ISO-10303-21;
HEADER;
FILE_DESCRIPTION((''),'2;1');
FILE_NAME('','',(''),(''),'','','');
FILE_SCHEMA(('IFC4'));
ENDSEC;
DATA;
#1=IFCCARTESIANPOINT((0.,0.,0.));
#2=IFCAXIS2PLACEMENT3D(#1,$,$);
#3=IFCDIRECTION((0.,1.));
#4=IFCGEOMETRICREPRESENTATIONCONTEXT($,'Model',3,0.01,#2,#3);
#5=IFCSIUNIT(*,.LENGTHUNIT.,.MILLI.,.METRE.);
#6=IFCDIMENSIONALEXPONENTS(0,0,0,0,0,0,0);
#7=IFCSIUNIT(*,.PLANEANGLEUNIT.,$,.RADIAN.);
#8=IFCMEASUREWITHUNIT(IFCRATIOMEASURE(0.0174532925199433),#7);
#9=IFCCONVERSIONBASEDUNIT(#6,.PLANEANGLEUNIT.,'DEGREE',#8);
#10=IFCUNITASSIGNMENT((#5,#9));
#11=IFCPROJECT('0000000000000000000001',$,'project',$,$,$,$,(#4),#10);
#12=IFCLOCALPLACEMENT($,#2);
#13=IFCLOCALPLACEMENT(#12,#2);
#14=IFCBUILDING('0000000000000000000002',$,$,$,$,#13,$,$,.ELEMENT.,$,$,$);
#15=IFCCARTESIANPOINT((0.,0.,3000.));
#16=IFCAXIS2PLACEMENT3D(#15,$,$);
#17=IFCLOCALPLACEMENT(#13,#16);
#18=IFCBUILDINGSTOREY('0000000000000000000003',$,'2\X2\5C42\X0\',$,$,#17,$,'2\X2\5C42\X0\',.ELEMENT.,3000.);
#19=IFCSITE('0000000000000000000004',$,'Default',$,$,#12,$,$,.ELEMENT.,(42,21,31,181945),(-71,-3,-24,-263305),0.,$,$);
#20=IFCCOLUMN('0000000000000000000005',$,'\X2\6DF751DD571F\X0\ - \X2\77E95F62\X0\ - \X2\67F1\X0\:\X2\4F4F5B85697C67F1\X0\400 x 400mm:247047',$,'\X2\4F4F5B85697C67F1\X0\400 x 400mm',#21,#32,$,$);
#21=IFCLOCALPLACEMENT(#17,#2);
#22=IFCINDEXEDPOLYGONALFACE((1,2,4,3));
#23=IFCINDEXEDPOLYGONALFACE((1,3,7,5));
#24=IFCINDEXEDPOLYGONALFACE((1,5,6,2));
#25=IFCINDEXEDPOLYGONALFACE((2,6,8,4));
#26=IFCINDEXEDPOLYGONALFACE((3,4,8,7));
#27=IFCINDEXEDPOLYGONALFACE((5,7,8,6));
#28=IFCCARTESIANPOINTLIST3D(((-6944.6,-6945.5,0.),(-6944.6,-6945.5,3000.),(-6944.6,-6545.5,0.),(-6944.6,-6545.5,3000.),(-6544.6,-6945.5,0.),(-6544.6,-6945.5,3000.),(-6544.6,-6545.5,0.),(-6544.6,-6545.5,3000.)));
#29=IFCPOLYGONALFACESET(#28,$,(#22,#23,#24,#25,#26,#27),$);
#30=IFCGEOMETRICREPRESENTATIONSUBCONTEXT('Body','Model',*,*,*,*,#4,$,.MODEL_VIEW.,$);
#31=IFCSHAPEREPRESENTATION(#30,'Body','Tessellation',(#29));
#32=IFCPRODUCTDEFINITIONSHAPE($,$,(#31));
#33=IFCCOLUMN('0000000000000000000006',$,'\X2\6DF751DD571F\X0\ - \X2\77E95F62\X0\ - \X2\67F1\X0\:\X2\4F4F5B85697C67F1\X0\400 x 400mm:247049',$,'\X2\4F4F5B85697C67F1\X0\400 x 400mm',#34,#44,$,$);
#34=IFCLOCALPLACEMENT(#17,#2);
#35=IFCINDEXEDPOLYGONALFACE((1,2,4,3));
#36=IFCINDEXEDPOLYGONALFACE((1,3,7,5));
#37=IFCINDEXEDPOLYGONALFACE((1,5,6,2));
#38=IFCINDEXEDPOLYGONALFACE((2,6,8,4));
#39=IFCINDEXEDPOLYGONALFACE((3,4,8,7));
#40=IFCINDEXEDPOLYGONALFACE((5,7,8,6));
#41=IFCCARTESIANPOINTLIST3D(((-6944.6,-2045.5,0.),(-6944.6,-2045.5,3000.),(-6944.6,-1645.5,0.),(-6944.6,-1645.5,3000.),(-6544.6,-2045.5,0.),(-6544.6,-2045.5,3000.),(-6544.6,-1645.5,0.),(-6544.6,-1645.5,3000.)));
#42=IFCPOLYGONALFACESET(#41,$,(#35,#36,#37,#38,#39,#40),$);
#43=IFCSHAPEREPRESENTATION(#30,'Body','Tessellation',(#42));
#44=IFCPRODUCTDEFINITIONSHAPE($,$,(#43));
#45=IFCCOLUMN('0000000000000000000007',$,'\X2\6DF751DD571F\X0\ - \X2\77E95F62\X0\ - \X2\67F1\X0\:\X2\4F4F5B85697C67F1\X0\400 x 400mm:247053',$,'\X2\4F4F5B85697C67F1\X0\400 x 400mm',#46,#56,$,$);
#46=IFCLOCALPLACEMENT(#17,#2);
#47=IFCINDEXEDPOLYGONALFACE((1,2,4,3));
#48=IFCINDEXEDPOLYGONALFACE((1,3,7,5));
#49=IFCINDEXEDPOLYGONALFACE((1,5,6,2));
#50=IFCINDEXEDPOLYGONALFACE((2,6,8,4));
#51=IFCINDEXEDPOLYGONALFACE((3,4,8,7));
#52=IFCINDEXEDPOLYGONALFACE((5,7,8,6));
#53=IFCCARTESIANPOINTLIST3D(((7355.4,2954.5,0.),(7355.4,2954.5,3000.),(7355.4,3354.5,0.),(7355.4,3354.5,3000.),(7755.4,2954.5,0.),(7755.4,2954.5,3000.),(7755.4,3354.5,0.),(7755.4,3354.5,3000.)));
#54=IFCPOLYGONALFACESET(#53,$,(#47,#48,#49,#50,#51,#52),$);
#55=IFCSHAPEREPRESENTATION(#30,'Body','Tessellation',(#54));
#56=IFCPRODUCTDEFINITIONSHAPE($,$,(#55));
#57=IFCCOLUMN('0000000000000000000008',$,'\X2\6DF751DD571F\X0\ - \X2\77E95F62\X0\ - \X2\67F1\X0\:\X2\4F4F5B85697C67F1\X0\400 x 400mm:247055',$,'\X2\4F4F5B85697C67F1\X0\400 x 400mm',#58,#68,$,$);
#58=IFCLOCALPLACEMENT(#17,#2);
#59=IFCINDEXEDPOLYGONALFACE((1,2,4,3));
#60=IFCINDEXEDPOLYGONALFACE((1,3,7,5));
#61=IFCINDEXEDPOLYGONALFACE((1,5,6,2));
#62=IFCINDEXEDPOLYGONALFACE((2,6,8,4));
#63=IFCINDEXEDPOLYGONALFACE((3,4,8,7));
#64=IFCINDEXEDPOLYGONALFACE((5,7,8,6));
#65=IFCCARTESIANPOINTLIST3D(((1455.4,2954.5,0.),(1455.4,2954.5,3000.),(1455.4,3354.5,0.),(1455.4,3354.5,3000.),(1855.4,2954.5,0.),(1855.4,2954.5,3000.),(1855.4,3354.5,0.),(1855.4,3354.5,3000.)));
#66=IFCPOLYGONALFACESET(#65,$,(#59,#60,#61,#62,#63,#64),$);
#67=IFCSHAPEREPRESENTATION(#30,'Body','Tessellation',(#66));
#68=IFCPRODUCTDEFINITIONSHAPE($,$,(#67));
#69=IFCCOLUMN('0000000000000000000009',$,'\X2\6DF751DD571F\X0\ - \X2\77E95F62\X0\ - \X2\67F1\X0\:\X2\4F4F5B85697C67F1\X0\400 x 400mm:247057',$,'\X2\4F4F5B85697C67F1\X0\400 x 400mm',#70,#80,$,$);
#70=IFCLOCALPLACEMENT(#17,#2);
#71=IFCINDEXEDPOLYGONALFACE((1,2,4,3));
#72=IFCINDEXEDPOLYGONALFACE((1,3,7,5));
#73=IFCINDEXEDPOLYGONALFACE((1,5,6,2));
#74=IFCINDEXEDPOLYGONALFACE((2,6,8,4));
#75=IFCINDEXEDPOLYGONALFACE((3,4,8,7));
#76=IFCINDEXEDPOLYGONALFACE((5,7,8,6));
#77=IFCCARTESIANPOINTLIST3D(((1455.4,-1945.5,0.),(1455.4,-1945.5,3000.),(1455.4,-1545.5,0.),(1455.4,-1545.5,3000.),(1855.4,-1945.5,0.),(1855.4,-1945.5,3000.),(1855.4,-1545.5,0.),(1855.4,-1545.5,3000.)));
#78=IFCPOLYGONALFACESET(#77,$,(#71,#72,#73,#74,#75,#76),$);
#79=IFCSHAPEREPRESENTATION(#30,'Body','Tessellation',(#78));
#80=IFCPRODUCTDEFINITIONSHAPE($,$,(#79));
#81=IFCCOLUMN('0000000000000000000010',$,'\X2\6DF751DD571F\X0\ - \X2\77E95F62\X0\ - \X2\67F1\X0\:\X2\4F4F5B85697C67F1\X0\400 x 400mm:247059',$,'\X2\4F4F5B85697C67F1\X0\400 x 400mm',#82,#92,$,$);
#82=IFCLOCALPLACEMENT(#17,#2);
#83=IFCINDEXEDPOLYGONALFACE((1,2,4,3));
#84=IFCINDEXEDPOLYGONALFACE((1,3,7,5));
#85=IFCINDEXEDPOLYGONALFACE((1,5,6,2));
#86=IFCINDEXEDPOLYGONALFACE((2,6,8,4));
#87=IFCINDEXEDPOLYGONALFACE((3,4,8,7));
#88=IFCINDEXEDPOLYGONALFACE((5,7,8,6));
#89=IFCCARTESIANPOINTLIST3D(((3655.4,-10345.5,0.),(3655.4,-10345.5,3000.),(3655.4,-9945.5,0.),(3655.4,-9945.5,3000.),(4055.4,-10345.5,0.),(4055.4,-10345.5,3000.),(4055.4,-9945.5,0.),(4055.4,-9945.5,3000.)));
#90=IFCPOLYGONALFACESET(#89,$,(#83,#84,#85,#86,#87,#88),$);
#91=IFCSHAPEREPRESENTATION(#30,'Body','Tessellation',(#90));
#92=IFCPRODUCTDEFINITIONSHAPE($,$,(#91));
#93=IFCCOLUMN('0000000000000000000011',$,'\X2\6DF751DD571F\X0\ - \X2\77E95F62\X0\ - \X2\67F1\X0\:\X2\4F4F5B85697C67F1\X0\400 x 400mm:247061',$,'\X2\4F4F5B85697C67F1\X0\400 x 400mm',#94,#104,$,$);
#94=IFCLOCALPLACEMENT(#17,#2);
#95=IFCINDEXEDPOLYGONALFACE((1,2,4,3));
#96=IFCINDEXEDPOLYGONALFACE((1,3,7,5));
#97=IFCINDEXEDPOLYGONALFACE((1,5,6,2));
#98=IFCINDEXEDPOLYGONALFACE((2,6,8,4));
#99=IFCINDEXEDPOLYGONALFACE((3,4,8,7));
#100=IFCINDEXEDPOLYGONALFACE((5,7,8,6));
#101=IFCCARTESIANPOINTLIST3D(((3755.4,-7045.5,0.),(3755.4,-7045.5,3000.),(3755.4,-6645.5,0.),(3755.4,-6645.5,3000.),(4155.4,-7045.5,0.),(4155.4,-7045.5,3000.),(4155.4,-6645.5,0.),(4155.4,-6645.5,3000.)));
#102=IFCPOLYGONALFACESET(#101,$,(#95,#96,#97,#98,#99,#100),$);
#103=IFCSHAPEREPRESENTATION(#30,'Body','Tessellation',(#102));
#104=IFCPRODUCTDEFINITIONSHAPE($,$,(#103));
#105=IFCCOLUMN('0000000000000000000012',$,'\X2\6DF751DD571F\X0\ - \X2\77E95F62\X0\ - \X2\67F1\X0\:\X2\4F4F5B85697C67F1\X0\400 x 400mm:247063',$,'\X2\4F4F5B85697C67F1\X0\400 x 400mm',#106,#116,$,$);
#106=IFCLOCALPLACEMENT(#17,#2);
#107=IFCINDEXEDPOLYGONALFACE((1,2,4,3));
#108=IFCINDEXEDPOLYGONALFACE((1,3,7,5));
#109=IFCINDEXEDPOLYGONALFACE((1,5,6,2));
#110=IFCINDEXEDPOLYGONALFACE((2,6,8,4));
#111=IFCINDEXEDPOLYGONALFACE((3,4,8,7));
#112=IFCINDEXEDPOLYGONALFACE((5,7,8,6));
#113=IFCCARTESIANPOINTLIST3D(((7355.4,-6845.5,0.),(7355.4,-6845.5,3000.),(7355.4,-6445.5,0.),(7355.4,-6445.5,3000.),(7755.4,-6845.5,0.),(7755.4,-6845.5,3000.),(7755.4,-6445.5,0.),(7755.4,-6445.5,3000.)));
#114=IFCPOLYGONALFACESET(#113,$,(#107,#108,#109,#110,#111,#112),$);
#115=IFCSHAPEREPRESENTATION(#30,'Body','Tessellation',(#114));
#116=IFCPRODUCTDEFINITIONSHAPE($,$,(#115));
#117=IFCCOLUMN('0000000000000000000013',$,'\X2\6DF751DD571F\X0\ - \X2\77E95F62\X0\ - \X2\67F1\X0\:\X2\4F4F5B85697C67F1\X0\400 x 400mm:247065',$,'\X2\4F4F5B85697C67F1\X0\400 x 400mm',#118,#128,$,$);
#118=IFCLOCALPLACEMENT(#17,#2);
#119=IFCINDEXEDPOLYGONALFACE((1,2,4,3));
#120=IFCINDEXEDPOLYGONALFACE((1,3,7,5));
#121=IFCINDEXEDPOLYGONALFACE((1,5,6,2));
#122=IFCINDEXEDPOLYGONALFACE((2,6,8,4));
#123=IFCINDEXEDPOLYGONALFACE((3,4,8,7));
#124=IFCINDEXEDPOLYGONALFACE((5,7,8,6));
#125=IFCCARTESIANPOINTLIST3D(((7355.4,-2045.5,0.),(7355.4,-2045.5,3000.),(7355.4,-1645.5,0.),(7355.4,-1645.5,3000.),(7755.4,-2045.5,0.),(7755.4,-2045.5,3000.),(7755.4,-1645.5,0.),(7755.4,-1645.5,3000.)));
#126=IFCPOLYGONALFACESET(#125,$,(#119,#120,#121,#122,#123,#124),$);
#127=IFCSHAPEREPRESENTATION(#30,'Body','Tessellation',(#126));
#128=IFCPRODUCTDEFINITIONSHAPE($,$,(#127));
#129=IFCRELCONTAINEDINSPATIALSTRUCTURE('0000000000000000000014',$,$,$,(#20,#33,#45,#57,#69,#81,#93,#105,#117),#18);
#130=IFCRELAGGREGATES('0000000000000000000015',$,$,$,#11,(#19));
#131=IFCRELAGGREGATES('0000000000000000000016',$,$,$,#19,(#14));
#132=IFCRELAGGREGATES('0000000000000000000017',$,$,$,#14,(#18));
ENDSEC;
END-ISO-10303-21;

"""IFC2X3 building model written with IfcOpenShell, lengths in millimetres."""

from ifc_helpers import new_model, entity, si_unit, converted_unit, direction, frame, frame_2d, origin, origin_2d_with_axis, place, context, subcontext, project, spatial, rectangle, extrude, source, transform, mapped, element, save


model = new_model("IFC2X3")

# Units and contexts
model_context = context("Model", 3, precision=0.01, world=origin(), true_north=direction((0.0, 1.0)))
body_context = subcontext(model_context, "Body", "Model", "MODEL_VIEW")
ifc_project = project(units=[si_unit("LENGTHUNIT", "METRE", prefix="MILLI"), converted_unit("PLANEANGLEUNIT", "DEGREE", entity("IfcRatioMeasure", 0.0174532925199433), si_unit("PLANEANGLEUNIT", "RADIAN"), dimensions=[0, 0, 0, 0, 0, 0, 0])], contexts=[model_context])

# Site, building, storey
site_placement = place(None, origin())
site = spatial("IfcSite", under=ifc_project, at=site_placement, Name="Default", CompositionType="ELEMENT", RefLatitude=(42, 21, 31, 181945), RefLongitude=(-71, -3, -24, -263305), RefElevation=0.0)
building_placement = place(site_placement, origin())
building = spatial("IfcBuilding", under=site, at=building_placement, CompositionType="ELEMENT")
storey_placement = place(building_placement, frame((0.0, 0.0, 3000.0)))
storey = spatial("IfcBuildingStorey", under=building, at=storey_placement, Name="2层", LongName="2层", CompositionType="ELEMENT", Elevation=3000.0)

# Columns
shared_shape_1 = source(origin(), body_context, "Body", "SweptSolid", [
    extrude(rectangle(XDim=400.0, YDim=400.0, at=origin_2d_with_axis()), frame((-6744.6, -6745.5, 3000.0), z_axis=(0.0, 0.0, 1.0), x_axis=(0.0, -1.0, 0.0)), (0.0, 0.0, 1.0), 3000.0),
])
column_1_placement = place(storey_placement, frame((0.0, 0.0, -3000.0)))
element("IfcColumn", 1, at=column_1_placement, inside=storey, Name="混凝土 - 矩形 - 柱:住宅楼柱400 x 400mm:247047", ObjectType="住宅楼柱400 x 400mm", context=body_context, shape_type="MappedRepresentation", body=[
    mapped(shared_shape_1, transform((0.0, 0.0, 0.0), scale=1.0)),
])
shared_shape_2 = source(origin(), body_context, "Body", "SweptSolid", [
    extrude(rectangle(XDim=400.0, YDim=400.0, at=origin_2d_with_axis()), frame((-6744.6, -1845.5, 3000.0), z_axis=(0.0, 0.0, 1.0), x_axis=(0.0, -1.0, 0.0)), (0.0, 0.0, 1.0), 3000.0),
])
column_2_placement = place(storey_placement, frame((0.0, 0.0, -3000.0)))
element("IfcColumn", 2, at=column_2_placement, inside=storey, Name="混凝土 - 矩形 - 柱:住宅楼柱400 x 400mm:247049", ObjectType="住宅楼柱400 x 400mm", context=body_context, shape_type="MappedRepresentation", body=[
    mapped(shared_shape_2, transform((0.0, 0.0, 0.0), scale=1.0)),
])
shared_shape_3 = source(origin(), body_context, "Body", "SweptSolid", [
    extrude(rectangle(XDim=400.0, YDim=400.0, at=origin_2d_with_axis()), frame((7555.4, 3154.5, 3000.0), z_axis=(0.0, 0.0, 1.0), x_axis=(0.0, -1.0, 0.0)), (0.0, 0.0, 1.0), 3000.0),
])
column_3_placement = place(storey_placement, frame((0.0, 0.0, -3000.0)))
element("IfcColumn", 3, at=column_3_placement, inside=storey, Name="混凝土 - 矩形 - 柱:住宅楼柱400 x 400mm:247053", ObjectType="住宅楼柱400 x 400mm", context=body_context, shape_type="MappedRepresentation", body=[
    mapped(shared_shape_3, transform((0.0, 0.0, 0.0), scale=1.0)),
])
shared_shape_4 = source(origin(), body_context, "Body", "SweptSolid", [
    extrude(rectangle(XDim=400.0, YDim=400.0, at=origin_2d_with_axis()), frame((1655.4, 3154.5, 3000.0), z_axis=(0.0, 0.0, 1.0), x_axis=(0.0, -1.0, 0.0)), (0.0, 0.0, 1.0), 3000.0),
])
column_4_placement = place(storey_placement, frame((0.0, 0.0, -3000.0)))
element("IfcColumn", 4, at=column_4_placement, inside=storey, Name="混凝土 - 矩形 - 柱:住宅楼柱400 x 400mm:247055", ObjectType="住宅楼柱400 x 400mm", context=body_context, shape_type="MappedRepresentation", body=[
    mapped(shared_shape_4, transform((0.0, 0.0, 0.0), scale=1.0)),
])
shared_shape_5 = source(origin(), body_context, "Body", "SweptSolid", [
    extrude(rectangle(XDim=400.0, YDim=400.0, at=frame_2d((0.0, 0.0), x_axis=(1.0, 0.0))), frame((1655.4, -1745.5, 3000.0), z_axis=(0.0, 0.0, 1.0), x_axis=(0.0, -1.0, 0.0)), (0.0, 0.0, 1.0), 3000.0),
])
column_5_placement = place(storey_placement, frame((0.0, 0.0, -3000.0)))
element("IfcColumn", 5, at=column_5_placement, inside=storey, Name="混凝土 - 矩形 - 柱:住宅楼柱400 x 400mm:247057", ObjectType="住宅楼柱400 x 400mm", context=body_context, shape_type="MappedRepresentation", body=[
    mapped(shared_shape_5, transform((0.0, 0.0, 0.0), scale=1.0)),
])
shared_shape_6 = source(origin(), body_context, "Body", "SweptSolid", [
    extrude(rectangle(XDim=400.0, YDim=400.0, at=origin_2d_with_axis()), frame((3855.4, -10145.5, 3000.0), z_axis=(0.0, 0.0, 1.0), x_axis=(0.0, -1.0, 0.0)), (0.0, 0.0, 1.0), 3000.0),
])
column_6_placement = place(storey_placement, frame((0.0, 0.0, -3000.0)))
element("IfcColumn", 6, at=column_6_placement, inside=storey, Name="混凝土 - 矩形 - 柱:住宅楼柱400 x 400mm:247059", ObjectType="住宅楼柱400 x 400mm", context=body_context, shape_type="MappedRepresentation", body=[
    mapped(shared_shape_6, transform((0.0, 0.0, 0.0), scale=1.0)),
])
shared_shape_7 = source(origin(), body_context, "Body", "SweptSolid", [
    extrude(rectangle(XDim=400.0, YDim=400.0, at=origin_2d_with_axis()), frame((3955.4, -6845.5, 3000.0), z_axis=(0.0, 0.0, 1.0), x_axis=(0.0, -1.0, 0.0)), (0.0, 0.0, 1.0), 3000.0),
])
column_7_placement = place(storey_placement, frame((0.0, 0.0, -3000.0)))
element("IfcColumn", 7, at=column_7_placement, inside=storey, Name="混凝土 - 矩形 - 柱:住宅楼柱400 x 400mm:247061", ObjectType="住宅楼柱400 x 400mm", context=body_context, shape_type="MappedRepresentation", body=[
    mapped(shared_shape_7, transform((0.0, 0.0, 0.0), scale=1.0)),
])
shared_shape_8 = source(origin(), body_context, "Body", "SweptSolid", [
    extrude(rectangle(XDim=400.0, YDim=400.0, at=origin_2d_with_axis()), frame((7555.4, -6645.5, 3000.0), z_axis=(0.0, 0.0, 1.0), x_axis=(0.0, -1.0, 0.0)), (0.0, 0.0, 1.0), 3000.0),
])
column_8_placement = place(storey_placement, frame((0.0, 0.0, -3000.0)))
element("IfcColumn", 8, at=column_8_placement, inside=storey, Name="混凝土 - 矩形 - 柱:住宅楼柱400 x 400mm:247063", ObjectType="住宅楼柱400 x 400mm", context=body_context, shape_type="MappedRepresentation", body=[
    mapped(shared_shape_8, transform((0.0, 0.0, 0.0), scale=1.0)),
])
shared_shape_9 = source(origin(), body_context, "Body", "SweptSolid", [
    extrude(rectangle(XDim=400.0, YDim=400.0, at=origin_2d_with_axis()), frame((7555.4, -1845.5, 3000.0), z_axis=(0.0, 0.0, 1.0), x_axis=(0.0, -1.0, 0.0)), (0.0, 0.0, 1.0), 3000.0),
])
column_9_placement = place(storey_placement, frame((0.0, 0.0, -3000.0)))
element("IfcColumn", 9, at=column_9_placement, inside=storey, Name="混凝土 - 矩形 - 柱:住宅楼柱400 x 400mm:247065", ObjectType="住宅楼柱400 x 400mm", context=body_context, shape_type="MappedRepresentation", body=[
    mapped(shared_shape_9, transform((0.0, 0.0, 0.0), scale=1.0)),
])

save(model, "model.ifc")
